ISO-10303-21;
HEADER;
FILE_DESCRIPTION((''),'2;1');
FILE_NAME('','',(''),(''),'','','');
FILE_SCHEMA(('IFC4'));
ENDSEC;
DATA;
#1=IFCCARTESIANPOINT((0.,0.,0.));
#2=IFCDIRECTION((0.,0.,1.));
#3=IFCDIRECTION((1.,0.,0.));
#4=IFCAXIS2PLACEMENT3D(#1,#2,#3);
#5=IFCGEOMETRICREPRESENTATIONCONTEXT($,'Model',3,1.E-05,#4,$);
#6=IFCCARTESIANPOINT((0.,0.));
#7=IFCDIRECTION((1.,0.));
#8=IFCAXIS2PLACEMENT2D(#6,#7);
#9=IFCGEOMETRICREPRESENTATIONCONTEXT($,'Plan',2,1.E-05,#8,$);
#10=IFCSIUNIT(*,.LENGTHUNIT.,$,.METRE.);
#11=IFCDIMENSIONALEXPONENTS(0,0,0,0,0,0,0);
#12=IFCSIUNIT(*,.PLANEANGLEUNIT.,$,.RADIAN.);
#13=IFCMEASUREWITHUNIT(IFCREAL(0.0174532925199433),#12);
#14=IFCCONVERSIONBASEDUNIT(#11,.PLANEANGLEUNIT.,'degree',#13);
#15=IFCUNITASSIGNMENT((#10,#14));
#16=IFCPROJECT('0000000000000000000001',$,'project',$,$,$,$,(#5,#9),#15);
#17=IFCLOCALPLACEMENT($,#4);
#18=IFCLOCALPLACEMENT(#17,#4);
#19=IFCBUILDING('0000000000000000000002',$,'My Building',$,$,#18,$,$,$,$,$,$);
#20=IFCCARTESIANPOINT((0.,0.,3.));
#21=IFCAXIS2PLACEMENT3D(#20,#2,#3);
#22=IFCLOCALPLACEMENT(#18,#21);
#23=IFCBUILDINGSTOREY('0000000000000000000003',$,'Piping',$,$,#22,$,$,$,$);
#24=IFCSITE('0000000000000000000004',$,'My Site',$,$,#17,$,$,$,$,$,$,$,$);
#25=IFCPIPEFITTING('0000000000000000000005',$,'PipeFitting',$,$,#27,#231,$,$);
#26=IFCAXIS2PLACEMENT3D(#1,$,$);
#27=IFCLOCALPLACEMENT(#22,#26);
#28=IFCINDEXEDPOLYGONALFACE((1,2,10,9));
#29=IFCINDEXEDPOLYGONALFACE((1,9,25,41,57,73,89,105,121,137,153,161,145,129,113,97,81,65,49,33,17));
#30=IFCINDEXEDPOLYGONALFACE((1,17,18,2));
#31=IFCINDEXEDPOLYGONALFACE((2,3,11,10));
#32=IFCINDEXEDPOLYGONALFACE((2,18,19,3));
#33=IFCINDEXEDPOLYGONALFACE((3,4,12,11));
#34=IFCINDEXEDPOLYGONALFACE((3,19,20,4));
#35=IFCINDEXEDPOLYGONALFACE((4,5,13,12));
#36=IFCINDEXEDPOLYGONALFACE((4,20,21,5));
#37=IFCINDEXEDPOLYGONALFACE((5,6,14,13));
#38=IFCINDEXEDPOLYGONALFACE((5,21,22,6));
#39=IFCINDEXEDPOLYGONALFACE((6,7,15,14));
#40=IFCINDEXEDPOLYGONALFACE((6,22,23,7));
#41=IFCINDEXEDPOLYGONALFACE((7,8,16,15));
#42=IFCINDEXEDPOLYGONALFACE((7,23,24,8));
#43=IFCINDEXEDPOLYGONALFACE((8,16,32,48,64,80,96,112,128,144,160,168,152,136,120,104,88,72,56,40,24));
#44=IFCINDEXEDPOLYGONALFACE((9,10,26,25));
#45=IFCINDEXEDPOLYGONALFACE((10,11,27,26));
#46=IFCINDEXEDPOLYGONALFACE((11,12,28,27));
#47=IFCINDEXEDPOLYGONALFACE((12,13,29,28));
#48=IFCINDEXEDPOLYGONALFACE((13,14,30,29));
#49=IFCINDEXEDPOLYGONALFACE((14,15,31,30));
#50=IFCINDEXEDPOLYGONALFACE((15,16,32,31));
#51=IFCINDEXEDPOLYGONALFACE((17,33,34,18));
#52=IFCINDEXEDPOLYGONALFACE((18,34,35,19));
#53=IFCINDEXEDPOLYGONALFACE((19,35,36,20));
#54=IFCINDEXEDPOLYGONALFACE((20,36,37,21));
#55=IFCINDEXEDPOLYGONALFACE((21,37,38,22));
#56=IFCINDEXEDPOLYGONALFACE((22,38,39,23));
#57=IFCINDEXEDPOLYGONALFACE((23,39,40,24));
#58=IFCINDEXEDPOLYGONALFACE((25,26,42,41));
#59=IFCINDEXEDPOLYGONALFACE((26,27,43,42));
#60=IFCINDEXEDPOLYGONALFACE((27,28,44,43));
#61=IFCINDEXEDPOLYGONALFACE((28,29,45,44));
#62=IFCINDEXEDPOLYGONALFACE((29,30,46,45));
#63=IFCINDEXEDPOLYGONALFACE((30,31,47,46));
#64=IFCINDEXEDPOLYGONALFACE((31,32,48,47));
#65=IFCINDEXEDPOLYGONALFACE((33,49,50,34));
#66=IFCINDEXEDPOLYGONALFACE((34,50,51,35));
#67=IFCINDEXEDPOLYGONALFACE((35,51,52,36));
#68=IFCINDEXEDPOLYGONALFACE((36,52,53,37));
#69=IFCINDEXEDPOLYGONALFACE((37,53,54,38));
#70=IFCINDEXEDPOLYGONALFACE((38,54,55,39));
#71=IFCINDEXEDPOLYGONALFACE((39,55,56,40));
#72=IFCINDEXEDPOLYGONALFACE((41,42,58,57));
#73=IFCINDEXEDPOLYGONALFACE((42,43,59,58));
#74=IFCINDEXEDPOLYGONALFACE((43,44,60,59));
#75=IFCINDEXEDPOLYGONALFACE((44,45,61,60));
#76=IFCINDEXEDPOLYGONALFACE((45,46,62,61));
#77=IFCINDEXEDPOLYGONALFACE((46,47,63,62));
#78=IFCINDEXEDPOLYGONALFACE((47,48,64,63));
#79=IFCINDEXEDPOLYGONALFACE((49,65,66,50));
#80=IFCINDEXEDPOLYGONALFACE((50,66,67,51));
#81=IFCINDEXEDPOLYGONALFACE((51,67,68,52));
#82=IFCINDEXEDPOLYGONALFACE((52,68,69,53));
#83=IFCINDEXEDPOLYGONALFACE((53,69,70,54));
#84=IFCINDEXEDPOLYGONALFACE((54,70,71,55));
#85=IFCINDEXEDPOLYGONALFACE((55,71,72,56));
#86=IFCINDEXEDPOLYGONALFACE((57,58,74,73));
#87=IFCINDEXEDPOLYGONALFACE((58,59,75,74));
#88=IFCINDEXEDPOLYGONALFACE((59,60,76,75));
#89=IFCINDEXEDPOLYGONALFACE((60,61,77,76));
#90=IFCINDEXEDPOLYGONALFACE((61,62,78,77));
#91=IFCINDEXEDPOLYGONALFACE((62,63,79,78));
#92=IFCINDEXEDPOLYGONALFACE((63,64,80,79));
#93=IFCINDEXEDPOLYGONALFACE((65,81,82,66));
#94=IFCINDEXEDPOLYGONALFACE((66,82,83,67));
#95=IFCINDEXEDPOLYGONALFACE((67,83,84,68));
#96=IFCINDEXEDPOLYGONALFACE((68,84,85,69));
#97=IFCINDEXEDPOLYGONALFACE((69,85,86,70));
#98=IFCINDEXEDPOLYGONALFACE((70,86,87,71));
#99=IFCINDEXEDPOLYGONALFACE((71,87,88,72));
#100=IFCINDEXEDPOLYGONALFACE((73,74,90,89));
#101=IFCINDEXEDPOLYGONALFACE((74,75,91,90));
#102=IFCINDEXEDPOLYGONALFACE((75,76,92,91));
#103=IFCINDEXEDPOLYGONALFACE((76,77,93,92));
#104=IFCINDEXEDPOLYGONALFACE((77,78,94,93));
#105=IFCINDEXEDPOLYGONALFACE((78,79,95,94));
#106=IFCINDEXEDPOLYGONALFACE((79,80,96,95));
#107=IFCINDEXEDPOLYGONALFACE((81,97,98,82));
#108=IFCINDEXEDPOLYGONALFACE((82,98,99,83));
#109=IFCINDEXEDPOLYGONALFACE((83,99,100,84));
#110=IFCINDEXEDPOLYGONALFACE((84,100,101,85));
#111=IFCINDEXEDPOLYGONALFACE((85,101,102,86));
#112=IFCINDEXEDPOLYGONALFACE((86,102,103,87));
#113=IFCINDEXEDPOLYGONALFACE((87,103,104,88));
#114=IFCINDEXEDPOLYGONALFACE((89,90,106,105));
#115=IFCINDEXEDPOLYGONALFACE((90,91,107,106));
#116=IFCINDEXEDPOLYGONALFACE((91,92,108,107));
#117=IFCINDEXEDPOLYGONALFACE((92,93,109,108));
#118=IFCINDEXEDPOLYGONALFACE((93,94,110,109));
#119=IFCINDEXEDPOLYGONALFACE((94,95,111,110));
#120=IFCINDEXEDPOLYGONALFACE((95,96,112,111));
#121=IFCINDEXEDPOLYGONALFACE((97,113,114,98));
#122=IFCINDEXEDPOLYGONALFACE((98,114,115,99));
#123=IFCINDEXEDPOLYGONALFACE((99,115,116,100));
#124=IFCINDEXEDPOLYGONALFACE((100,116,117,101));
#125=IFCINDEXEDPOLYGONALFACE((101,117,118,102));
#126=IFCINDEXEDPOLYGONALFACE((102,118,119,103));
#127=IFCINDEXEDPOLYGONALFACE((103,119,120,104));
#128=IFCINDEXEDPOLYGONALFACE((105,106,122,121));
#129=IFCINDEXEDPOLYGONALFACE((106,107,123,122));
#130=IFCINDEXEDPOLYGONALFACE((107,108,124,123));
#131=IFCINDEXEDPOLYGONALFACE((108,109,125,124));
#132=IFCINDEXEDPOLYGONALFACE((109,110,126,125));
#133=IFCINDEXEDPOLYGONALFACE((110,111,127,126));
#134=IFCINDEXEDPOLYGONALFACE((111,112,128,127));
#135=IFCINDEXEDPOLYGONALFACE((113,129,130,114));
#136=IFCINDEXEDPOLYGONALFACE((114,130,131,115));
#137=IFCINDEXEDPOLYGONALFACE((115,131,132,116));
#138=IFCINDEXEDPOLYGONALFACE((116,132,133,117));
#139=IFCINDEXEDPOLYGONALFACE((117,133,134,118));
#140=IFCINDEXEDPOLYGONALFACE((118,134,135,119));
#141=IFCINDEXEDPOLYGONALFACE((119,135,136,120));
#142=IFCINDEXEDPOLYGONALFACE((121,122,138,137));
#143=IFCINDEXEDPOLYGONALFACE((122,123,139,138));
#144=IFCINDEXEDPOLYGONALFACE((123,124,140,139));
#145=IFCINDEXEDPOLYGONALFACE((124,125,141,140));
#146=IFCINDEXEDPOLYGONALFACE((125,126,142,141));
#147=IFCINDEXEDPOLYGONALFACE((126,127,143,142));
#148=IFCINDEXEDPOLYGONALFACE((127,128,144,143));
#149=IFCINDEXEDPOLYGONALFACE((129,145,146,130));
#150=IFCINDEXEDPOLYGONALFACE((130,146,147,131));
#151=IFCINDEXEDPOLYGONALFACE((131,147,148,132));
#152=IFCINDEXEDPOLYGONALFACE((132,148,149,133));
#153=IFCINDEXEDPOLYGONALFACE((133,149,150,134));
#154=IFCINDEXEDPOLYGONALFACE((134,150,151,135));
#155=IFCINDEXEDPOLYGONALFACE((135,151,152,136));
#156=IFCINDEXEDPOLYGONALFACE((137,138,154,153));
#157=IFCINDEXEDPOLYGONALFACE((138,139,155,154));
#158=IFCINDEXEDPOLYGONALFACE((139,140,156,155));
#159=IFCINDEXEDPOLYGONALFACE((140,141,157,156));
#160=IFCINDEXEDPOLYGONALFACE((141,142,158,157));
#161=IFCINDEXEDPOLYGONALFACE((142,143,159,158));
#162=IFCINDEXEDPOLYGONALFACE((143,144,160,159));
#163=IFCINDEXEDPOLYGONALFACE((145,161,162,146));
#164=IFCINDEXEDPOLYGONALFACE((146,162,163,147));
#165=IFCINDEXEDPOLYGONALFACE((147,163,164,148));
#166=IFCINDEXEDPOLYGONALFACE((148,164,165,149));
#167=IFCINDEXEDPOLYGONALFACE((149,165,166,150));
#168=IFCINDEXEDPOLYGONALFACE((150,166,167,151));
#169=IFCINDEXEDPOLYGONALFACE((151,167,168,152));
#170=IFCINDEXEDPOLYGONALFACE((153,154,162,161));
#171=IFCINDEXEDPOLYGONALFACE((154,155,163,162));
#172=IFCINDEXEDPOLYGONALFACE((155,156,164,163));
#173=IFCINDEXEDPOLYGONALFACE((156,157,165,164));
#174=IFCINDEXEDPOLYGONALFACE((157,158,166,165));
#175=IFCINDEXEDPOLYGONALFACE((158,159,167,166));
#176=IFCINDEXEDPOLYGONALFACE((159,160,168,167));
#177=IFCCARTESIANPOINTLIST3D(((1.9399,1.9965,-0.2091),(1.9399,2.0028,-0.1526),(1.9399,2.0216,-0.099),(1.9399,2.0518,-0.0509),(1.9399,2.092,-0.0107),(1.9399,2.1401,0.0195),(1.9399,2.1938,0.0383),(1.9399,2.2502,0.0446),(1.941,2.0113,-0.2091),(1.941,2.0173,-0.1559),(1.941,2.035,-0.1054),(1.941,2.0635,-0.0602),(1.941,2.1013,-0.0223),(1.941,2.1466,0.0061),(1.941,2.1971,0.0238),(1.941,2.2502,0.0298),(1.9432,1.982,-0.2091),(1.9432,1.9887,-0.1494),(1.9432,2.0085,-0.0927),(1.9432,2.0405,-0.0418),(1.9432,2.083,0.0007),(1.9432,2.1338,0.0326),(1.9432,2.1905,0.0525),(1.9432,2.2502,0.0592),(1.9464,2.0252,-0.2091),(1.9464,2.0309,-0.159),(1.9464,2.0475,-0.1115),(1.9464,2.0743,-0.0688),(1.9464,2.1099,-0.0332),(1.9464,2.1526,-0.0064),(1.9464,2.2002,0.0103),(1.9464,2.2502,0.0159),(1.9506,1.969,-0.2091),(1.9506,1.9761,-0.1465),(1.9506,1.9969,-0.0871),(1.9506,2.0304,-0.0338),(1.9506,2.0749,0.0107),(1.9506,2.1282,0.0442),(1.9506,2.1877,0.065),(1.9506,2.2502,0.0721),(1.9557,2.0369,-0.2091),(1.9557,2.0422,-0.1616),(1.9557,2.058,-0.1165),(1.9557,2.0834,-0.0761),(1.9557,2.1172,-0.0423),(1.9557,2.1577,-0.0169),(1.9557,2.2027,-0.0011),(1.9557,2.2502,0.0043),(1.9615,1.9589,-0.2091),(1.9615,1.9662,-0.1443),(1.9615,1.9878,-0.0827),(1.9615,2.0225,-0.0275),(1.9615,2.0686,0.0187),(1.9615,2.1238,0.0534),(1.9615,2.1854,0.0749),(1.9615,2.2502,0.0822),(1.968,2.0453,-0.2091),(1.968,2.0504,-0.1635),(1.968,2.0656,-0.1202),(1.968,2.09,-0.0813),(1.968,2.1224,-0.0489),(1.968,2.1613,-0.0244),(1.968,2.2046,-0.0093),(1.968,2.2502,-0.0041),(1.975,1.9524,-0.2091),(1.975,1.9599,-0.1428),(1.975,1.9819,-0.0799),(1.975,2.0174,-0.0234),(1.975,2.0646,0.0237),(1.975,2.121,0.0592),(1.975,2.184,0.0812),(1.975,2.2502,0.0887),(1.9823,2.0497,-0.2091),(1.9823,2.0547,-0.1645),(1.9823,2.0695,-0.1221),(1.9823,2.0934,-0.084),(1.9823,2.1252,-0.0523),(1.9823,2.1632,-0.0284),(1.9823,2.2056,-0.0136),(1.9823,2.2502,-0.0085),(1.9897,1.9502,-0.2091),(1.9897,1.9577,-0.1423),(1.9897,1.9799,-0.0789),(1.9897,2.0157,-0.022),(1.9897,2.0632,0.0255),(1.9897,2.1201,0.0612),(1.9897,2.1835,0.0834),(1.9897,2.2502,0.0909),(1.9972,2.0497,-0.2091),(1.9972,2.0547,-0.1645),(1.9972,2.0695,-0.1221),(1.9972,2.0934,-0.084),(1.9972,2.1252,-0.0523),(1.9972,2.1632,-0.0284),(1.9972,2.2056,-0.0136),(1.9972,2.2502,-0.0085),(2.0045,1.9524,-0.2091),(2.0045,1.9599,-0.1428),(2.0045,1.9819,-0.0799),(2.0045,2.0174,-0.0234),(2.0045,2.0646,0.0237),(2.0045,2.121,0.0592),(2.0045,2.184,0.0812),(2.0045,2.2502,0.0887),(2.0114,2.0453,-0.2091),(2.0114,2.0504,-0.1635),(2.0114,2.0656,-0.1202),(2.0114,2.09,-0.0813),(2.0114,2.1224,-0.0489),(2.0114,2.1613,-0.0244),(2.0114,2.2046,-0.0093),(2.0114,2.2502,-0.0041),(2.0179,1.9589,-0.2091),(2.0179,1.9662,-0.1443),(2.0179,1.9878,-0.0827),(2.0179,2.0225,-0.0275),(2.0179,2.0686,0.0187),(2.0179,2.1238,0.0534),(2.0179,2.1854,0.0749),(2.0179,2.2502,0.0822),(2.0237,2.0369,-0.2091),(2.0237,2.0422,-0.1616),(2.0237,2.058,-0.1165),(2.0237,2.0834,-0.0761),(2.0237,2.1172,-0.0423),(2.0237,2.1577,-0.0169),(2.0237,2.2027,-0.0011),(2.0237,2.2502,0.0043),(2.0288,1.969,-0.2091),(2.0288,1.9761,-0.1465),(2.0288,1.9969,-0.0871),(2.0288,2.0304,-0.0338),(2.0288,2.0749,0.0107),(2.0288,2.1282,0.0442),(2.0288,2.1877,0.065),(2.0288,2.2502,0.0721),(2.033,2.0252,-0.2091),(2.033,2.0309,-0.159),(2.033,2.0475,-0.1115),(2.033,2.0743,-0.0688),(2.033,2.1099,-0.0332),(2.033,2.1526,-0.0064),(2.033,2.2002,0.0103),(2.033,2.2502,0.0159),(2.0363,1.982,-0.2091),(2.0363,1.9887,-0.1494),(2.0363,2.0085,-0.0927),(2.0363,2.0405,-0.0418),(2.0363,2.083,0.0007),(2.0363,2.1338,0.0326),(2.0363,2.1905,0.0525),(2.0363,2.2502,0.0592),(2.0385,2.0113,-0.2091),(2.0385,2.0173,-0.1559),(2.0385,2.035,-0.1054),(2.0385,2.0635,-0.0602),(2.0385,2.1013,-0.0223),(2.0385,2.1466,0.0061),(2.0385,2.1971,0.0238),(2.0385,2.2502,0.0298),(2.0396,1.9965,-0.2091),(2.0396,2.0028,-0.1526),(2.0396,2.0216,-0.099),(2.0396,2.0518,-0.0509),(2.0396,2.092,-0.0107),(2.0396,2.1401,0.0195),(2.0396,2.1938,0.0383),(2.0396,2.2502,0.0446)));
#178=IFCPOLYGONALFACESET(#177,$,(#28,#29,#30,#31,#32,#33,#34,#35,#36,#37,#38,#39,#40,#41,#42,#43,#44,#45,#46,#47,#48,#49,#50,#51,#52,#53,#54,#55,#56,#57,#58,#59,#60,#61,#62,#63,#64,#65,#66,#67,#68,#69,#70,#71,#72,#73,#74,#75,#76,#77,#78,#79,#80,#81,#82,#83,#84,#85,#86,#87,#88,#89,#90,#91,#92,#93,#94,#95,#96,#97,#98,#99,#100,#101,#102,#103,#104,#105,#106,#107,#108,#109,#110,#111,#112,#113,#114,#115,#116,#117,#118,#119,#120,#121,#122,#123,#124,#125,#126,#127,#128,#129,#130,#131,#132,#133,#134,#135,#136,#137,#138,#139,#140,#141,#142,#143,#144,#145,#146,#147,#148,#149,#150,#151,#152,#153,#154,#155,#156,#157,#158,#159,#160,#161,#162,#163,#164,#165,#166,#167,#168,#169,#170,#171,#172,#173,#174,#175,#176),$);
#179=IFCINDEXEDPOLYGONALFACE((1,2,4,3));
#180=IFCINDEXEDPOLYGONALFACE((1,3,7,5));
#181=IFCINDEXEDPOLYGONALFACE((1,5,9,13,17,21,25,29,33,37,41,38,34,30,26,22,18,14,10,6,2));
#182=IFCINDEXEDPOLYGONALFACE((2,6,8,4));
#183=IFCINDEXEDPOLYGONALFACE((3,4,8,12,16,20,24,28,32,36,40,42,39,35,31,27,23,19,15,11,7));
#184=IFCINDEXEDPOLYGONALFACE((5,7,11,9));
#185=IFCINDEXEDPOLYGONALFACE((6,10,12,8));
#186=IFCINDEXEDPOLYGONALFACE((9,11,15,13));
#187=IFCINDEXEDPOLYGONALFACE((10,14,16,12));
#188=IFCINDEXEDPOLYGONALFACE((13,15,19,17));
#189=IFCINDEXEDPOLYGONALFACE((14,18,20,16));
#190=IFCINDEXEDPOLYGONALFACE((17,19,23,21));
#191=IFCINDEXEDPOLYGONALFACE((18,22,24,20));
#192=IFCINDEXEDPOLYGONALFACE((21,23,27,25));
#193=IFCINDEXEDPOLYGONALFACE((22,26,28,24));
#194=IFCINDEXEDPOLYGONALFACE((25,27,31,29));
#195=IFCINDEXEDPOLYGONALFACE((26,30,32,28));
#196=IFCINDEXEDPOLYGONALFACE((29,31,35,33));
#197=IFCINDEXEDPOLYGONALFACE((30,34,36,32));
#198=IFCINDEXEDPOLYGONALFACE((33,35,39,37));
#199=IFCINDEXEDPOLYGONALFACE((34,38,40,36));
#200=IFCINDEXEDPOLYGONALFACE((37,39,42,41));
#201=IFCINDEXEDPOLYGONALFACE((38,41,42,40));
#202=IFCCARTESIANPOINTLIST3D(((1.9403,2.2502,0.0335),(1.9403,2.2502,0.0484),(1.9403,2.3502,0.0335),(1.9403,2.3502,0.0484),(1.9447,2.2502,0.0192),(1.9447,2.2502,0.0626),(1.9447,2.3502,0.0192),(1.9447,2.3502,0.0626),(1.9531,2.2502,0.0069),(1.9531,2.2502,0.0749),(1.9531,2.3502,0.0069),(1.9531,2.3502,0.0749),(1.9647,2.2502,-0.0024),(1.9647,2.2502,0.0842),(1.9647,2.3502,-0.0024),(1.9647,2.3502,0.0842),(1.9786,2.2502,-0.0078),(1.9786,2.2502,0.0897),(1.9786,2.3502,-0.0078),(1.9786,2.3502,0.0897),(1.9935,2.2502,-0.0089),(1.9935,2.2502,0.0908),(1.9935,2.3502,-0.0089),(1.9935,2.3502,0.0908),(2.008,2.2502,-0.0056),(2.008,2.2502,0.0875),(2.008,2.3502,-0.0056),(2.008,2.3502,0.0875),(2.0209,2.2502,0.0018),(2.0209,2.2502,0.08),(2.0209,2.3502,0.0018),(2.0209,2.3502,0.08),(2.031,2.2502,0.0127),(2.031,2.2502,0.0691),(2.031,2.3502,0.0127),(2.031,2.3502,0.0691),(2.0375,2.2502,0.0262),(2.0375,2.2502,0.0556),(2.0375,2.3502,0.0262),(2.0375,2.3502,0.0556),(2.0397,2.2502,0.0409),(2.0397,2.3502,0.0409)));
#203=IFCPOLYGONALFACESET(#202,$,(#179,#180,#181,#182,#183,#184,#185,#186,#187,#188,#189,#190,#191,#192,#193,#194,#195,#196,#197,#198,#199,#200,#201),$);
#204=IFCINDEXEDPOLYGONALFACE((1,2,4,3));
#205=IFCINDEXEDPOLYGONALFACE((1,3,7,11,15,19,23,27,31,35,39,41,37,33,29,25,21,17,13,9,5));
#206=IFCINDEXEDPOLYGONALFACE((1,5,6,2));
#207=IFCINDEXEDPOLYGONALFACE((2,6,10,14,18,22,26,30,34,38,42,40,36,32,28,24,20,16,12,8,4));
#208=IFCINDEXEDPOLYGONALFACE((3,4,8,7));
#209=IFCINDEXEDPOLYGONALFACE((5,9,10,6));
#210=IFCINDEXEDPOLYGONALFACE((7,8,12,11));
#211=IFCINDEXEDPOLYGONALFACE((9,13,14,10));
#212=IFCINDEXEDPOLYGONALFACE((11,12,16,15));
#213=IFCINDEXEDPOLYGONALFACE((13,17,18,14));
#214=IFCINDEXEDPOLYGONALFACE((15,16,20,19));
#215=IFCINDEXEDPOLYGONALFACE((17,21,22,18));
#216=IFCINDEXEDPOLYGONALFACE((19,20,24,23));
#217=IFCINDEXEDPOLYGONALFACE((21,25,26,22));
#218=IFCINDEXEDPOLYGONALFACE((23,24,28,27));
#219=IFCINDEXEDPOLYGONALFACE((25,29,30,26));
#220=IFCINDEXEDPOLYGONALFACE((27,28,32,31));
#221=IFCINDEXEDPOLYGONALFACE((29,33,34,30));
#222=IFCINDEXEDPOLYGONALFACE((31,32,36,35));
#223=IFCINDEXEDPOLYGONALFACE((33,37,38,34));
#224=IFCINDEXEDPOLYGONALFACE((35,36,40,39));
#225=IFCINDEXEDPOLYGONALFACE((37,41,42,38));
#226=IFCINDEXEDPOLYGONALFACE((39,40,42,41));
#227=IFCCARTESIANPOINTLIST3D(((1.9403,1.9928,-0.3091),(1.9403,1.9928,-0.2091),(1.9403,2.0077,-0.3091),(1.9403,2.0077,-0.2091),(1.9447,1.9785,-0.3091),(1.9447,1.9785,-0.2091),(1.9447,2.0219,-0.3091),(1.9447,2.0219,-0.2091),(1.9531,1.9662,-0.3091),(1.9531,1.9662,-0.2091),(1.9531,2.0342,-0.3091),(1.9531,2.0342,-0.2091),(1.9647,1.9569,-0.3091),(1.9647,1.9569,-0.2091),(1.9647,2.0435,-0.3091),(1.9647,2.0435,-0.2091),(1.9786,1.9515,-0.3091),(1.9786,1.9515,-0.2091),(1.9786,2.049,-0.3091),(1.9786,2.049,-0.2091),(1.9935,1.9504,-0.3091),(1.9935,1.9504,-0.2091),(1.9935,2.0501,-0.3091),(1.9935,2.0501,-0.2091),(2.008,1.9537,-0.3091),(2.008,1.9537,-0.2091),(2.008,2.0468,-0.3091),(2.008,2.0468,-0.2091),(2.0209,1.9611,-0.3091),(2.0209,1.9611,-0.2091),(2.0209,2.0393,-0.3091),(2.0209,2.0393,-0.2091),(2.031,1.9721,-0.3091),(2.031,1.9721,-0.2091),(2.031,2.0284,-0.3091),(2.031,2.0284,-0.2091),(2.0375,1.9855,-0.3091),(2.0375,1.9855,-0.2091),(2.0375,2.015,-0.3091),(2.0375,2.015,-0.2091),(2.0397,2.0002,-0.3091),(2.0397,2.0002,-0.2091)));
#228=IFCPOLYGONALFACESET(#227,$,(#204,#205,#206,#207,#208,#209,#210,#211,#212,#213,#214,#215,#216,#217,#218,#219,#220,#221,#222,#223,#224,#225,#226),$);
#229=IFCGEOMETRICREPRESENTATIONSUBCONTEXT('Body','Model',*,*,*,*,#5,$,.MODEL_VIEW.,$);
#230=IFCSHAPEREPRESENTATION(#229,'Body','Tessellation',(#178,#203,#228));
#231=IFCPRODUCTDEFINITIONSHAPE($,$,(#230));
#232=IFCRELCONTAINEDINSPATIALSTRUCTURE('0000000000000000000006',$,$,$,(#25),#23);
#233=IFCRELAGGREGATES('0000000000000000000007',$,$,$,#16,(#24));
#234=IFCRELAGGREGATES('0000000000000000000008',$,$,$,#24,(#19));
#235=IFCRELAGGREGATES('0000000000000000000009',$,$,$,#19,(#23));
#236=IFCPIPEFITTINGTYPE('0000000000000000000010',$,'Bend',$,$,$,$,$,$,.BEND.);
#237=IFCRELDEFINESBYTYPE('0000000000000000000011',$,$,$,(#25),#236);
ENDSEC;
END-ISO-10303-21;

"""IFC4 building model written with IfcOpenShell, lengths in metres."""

from ifc_helpers import new_model, entity, si_unit, converted_unit, frame, origin_with_axes, origin_2d_with_axis, place, context, subcontext, project, spatial, circle, extrude, source, transform, mapped, type_object, type_shapes, element, save


model = new_model("IFC4")

# Units and contexts
model_context = context("Model", 3, precision=1e-05, world=origin_with_axes())
plan_context = context("Plan", 2, precision=1e-05, world=origin_2d_with_axis())
body_context = subcontext(model_context, "Body", "Model", "MODEL_VIEW")
ifc_project = project(units=[si_unit("LENGTHUNIT", "METRE"), converted_unit("PLANEANGLEUNIT", "degree", entity("IfcReal", 0.0174532925199433), si_unit("PLANEANGLEUNIT", "RADIAN"), dimensions=[0, 0, 0, 0, 0, 0, 0])], contexts=[model_context, plan_context])

# Site, building, storey
site_placement = place(None, origin_with_axes())
site = spatial("IfcSite", under=ifc_project, at=site_placement, Name="My Site")
building_placement = place(site_placement, origin_with_axes())
building = spatial("IfcBuilding", under=site, at=building_placement, Name="My Building")
storey_placement = place(building_placement, frame((0.0, 0.0, 3.0), z_axis=(0.0, 0.0, 1.0), x_axis=(1.0, 0.0, 0.0)))
storey = spatial("IfcBuildingStorey", under=building, at=storey_placement, Name="Piping")

# Pipe fitting
pipe_fitting_type_1 = type_object("IfcPipeFittingType", Name="Bend", PredefinedType="BEND")
shared_shape = source(origin_with_axes(), body_context, "Body", "SolidModel", [
    entity("IfcSweptDiskSolid", entity("IfcIndexedPolyCurve", entity("IfcCartesianPointList3D", [[0.0, 0.0, 0.1], [0.0, -0.0732, 0.2768], [0.0, -0.25, 0.35]]), [entity("IfcArcIndex", [1, 2, 3])]), 0.05),
    extrude(circle(Radius=0.05), origin_with_axes(), (0.0, 0.0, 1.0), 0.1),
    extrude(circle(Radius=0.05), frame((0.0, -0.25, 0.35), z_axis=(0.0, -1.0, -0.000003), x_axis=(1.0, 0.0, 0.0)), (0.0, 0.0, 1.0), 0.1),
])
type_shapes(pipe_fitting_type_1, [shared_shape])
for number, where, z_axis, x_axis, name in (
    (1, (1.9897, 2.3502, 0.0409), (0.0, -1.0, 0.0), (1.0, 0.0, 0.0), "PipeFitting"),
):
    element("IfcPipeFitting", number, at=place(storey_placement, frame(where, z_axis=z_axis, x_axis=x_axis)), inside=storey, type_object=pipe_fitting_type_1, Name=name, context=body_context, shape_type="MappedRepresentation", body=[
        mapped(shared_shape, transform((0.0, 0.0, 0.0), x_axis=(1.0, 0.0, 0.0), y_axis=(0.0, 1.0, 0.0), z_axis=(0.0, 0.0, 1.0), scale=1.0)),
    ])

save(model, "model.ifc")
